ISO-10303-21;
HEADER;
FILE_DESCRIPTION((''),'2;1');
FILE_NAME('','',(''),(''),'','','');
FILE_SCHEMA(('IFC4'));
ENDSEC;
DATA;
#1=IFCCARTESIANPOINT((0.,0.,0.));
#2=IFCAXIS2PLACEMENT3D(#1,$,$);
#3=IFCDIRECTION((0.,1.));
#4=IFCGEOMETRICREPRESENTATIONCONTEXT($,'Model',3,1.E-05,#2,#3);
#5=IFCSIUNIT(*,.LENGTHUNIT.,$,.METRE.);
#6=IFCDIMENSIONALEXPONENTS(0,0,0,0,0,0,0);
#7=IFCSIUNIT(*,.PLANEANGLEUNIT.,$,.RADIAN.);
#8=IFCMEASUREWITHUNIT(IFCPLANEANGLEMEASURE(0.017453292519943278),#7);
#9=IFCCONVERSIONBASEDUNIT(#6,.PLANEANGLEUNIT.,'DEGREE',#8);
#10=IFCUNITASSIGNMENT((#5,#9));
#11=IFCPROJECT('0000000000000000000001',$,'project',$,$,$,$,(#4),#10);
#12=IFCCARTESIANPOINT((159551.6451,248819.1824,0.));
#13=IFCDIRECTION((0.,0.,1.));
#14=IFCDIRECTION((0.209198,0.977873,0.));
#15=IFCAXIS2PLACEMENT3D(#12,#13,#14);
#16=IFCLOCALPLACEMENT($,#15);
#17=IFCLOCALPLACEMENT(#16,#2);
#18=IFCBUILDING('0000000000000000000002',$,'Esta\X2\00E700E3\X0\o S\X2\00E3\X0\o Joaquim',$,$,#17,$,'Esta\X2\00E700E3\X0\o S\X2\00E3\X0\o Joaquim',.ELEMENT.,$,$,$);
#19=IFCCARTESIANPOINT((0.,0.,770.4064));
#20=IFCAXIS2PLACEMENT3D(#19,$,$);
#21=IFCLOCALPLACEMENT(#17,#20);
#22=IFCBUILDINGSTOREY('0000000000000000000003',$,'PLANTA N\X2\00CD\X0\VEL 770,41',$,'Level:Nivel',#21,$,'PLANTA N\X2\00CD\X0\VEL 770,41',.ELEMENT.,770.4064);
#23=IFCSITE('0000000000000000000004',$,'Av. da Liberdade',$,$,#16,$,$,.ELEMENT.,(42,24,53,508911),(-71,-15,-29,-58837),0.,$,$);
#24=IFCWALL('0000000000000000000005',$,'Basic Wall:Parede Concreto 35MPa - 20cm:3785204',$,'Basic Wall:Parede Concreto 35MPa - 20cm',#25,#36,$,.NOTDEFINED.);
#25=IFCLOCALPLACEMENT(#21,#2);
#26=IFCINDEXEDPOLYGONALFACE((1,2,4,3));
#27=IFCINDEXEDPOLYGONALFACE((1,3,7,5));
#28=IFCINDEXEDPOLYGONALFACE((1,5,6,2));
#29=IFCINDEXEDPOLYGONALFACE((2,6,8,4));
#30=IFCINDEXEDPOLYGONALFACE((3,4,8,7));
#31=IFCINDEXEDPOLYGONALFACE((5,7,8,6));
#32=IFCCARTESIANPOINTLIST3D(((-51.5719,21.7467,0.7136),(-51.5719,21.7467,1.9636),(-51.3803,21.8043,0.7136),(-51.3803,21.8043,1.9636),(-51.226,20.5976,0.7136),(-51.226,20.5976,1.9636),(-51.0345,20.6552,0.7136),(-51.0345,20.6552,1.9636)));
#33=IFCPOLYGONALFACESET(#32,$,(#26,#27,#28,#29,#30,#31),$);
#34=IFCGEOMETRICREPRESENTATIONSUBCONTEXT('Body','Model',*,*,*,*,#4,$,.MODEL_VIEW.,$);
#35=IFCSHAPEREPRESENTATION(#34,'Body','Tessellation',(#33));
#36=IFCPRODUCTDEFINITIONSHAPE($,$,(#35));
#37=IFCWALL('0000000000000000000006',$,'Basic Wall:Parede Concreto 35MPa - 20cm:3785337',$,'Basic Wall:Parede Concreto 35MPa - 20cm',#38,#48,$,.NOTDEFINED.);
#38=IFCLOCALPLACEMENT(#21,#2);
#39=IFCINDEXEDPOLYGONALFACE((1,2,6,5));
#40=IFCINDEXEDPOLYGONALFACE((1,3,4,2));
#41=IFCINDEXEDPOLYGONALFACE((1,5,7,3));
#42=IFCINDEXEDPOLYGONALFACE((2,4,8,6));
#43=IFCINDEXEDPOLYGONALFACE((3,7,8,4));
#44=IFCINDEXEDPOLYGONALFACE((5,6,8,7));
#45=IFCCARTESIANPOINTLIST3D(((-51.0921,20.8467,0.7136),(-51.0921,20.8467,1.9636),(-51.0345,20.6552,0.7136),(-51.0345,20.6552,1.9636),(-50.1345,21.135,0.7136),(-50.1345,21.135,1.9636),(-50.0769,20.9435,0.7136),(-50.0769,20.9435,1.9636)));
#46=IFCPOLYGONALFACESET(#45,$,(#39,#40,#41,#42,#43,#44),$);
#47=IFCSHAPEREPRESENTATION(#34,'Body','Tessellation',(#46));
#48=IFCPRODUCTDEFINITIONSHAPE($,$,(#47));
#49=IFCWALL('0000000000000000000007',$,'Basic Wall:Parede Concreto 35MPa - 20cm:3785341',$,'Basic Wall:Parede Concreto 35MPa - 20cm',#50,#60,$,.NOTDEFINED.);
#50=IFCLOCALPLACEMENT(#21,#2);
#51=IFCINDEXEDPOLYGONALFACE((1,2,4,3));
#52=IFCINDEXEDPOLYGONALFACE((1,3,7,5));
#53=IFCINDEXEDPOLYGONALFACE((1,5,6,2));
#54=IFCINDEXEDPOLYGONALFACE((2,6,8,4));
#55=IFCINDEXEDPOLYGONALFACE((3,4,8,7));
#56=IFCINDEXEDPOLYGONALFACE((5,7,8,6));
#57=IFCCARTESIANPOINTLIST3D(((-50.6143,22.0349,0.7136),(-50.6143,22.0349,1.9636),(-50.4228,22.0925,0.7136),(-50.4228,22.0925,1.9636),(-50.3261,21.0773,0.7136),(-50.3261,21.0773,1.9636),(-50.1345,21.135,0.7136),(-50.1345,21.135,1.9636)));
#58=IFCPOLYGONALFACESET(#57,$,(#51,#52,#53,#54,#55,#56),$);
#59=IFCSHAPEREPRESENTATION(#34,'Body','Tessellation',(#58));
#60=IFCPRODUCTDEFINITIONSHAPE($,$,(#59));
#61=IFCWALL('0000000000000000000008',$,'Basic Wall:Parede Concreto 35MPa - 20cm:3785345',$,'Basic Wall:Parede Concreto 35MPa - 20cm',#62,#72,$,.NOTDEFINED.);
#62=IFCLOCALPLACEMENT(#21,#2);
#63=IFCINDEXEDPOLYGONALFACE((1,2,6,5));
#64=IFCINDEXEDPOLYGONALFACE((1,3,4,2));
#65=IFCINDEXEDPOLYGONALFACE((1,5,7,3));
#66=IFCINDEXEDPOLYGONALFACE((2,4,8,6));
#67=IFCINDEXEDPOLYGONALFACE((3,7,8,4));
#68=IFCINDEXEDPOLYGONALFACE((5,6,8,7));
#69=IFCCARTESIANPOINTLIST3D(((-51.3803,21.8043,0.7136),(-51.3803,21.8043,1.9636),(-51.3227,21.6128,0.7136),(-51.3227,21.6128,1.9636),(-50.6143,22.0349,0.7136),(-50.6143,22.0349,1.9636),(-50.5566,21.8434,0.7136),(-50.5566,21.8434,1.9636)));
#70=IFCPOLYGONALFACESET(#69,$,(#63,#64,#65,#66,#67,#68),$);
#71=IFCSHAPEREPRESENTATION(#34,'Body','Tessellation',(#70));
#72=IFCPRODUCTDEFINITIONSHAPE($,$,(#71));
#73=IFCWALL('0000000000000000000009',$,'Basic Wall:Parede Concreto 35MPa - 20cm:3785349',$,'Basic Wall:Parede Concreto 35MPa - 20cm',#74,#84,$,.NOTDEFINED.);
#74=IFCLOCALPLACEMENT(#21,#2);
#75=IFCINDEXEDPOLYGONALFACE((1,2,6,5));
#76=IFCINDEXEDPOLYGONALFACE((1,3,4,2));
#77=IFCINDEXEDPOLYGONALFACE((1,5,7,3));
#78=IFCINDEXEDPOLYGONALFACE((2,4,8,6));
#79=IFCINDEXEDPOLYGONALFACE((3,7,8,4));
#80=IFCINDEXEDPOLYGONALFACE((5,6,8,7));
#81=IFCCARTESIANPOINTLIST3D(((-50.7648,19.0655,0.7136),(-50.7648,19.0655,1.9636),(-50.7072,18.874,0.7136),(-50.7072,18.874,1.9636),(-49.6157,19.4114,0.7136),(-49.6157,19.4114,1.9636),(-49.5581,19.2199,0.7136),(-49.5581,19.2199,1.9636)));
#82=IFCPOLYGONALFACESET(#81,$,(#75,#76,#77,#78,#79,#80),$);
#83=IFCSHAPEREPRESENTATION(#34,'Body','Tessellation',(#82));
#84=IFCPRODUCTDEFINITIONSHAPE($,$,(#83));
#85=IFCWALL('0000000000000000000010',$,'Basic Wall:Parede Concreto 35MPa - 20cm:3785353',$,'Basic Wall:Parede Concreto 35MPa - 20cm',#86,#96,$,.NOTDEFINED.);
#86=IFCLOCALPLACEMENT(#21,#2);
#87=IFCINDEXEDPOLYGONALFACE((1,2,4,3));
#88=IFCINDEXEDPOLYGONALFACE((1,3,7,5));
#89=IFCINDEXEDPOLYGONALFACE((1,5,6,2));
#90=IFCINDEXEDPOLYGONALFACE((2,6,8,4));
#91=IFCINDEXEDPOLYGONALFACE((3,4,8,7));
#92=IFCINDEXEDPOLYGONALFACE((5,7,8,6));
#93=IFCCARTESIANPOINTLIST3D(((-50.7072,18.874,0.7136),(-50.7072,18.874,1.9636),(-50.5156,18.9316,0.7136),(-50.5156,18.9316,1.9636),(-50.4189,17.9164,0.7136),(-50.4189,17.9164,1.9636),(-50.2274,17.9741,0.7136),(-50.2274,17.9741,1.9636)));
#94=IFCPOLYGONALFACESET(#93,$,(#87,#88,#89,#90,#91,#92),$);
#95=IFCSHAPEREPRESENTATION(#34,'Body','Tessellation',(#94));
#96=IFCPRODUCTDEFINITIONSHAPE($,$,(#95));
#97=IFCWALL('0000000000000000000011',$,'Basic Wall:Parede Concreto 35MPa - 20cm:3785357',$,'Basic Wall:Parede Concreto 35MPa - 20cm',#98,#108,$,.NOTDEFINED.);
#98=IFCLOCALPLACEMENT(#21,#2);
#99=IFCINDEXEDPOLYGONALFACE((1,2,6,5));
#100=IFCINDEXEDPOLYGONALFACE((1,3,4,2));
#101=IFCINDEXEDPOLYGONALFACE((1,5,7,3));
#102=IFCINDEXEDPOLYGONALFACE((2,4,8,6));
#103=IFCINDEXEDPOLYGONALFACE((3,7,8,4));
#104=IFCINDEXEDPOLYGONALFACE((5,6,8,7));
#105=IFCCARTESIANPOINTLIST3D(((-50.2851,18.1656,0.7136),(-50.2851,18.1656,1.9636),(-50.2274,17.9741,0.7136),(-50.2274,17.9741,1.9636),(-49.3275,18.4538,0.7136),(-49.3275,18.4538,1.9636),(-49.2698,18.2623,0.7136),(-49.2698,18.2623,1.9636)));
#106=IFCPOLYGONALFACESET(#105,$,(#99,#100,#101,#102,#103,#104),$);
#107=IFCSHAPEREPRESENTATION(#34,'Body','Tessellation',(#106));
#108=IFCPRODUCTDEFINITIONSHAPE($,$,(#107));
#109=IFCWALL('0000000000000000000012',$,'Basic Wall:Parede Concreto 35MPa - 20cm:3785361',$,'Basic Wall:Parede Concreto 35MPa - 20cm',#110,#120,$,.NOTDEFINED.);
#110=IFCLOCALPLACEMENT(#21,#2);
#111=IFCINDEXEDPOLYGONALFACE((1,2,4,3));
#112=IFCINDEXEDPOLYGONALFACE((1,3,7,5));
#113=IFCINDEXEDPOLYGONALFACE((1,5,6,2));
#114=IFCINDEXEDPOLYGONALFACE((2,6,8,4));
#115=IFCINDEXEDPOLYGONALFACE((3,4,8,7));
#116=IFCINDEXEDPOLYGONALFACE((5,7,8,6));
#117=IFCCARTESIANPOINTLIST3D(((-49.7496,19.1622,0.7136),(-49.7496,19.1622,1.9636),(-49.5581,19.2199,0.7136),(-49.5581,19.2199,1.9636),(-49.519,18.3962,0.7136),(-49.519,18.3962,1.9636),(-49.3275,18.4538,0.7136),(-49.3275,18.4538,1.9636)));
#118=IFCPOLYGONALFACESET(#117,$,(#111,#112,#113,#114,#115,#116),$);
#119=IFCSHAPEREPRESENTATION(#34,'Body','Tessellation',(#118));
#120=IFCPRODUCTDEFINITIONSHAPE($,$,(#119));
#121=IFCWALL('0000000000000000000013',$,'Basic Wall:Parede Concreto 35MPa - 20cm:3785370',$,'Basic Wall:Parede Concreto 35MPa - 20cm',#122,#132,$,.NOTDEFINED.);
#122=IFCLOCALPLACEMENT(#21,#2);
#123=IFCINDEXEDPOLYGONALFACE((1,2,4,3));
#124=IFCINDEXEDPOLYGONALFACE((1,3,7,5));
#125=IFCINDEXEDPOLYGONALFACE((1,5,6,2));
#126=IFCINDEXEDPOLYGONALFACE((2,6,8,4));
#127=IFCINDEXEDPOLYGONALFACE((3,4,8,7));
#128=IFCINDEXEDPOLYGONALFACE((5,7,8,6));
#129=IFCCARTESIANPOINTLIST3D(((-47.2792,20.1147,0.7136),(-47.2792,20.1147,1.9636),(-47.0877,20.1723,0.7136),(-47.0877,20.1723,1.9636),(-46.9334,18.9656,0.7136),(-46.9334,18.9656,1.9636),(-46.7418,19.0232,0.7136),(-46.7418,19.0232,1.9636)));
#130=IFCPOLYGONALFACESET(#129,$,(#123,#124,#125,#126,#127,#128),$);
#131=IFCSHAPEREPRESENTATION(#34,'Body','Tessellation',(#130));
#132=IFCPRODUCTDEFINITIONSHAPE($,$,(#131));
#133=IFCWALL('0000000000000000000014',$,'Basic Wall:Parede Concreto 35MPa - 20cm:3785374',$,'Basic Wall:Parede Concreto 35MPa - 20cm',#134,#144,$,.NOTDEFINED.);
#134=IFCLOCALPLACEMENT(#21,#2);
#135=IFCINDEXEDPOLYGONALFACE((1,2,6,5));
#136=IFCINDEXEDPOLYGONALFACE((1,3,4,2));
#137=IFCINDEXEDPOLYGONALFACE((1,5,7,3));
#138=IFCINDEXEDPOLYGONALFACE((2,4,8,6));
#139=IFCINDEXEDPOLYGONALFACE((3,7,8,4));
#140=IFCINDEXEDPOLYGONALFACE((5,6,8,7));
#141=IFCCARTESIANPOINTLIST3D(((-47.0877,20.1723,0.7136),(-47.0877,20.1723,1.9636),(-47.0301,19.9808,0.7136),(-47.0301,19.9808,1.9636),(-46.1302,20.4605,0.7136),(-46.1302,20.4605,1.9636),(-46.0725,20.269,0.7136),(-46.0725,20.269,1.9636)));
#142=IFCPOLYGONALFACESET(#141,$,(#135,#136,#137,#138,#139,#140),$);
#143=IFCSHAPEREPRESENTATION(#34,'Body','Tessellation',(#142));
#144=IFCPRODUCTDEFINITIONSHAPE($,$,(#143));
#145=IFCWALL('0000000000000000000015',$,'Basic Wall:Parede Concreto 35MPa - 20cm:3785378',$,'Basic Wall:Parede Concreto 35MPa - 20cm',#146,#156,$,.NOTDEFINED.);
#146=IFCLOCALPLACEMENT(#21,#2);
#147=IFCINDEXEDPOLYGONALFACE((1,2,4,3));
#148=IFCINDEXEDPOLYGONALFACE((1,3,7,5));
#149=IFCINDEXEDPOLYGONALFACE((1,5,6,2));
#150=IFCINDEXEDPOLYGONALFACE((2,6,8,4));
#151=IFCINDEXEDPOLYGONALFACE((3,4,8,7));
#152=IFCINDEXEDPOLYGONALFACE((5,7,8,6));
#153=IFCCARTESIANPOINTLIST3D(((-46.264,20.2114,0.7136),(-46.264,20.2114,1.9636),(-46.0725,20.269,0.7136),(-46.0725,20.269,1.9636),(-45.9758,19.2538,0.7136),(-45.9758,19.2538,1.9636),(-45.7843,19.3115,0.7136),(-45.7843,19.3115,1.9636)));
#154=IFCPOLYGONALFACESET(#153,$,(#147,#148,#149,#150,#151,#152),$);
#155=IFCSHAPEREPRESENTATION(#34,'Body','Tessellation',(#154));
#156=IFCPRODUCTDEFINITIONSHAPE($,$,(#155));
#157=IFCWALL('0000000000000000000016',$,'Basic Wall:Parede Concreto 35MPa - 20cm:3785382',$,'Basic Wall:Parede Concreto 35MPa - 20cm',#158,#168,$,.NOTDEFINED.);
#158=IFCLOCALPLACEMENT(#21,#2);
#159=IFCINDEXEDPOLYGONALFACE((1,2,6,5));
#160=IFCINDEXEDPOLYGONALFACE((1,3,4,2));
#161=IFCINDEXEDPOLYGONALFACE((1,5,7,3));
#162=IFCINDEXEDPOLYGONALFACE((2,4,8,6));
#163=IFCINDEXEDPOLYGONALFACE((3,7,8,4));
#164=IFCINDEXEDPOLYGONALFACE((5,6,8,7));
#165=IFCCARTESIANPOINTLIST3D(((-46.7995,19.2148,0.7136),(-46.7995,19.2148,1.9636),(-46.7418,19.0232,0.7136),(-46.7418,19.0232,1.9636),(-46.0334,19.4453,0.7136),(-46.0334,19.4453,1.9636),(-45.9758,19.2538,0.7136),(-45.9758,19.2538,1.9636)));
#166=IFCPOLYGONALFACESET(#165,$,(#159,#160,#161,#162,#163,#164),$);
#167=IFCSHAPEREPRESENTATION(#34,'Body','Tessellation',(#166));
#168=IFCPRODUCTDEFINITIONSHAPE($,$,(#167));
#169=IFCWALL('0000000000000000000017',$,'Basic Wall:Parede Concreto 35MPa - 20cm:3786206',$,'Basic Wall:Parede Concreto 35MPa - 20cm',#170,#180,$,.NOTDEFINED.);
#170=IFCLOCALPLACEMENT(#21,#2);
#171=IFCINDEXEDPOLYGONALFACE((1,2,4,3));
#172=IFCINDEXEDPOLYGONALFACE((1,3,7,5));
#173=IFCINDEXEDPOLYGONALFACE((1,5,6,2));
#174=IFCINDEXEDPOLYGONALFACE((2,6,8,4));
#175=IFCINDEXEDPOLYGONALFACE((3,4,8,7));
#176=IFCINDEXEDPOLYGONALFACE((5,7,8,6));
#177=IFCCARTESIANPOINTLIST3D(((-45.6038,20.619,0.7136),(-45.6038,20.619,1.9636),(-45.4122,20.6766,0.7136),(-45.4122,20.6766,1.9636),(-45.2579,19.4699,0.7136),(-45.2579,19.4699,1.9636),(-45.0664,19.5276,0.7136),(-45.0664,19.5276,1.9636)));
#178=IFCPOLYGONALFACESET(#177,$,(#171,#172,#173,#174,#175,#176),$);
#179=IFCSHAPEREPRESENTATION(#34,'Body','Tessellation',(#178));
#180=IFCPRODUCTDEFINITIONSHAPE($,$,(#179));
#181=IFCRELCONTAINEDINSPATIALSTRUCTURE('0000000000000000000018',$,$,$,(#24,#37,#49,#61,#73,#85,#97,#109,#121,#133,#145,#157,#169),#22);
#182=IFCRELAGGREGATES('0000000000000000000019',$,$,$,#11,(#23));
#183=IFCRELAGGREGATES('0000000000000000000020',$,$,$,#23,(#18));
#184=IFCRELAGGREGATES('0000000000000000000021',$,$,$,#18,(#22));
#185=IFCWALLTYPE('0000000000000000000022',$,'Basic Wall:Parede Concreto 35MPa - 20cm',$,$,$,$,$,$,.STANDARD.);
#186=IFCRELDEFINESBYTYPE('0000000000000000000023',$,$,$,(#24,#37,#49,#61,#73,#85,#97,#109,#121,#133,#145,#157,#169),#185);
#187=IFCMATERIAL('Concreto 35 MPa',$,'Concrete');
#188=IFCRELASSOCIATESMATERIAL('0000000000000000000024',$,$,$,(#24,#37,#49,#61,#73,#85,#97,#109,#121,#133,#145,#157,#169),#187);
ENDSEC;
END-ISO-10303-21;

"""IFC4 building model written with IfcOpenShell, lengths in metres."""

from ifc_helpers import new_model, entity, si_unit, converted_unit, direction, frame, origin, place, context, subcontext, project, spatial, indexed_curve, outline, extrude, material, type_object, element, save


model = new_model("IFC4")

# Units and contexts
model_context = context("Model", 3, precision=1e-05, world=origin(), true_north=direction((0.0, 1.0)))
body_context = subcontext(model_context, "Body", "Model", "MODEL_VIEW")
ifc_project = project(units=[si_unit("LENGTHUNIT", "METRE"), converted_unit("PLANEANGLEUNIT", "DEGREE", entity("IfcPlaneAngleMeasure", 0.017453292519943278), si_unit("PLANEANGLEUNIT", "RADIAN"), dimensions=[0, 0, 0, 0, 0, 0, 0])], contexts=[model_context])

# Site, building, storey
site_placement = place(None, frame((159551.6451, 248819.1824, 0.0), z_axis=(0.0, 0.0, 1.0), x_axis=(0.209198, 0.977873, 0.0)))
site = spatial("IfcSite", under=ifc_project, at=site_placement, Name="Av. da Liberdade", CompositionType="ELEMENT", RefLatitude=(42, 24, 53, 508911), RefLongitude=(-71, -15, -29, -58837), RefElevation=0.0)
building_placement = place(site_placement, origin())
building = spatial("IfcBuilding", under=site, at=building_placement, Name="Estação São Joaquim", LongName="Estação São Joaquim", CompositionType="ELEMENT")
storey_placement = place(building_placement, frame((0.0, 0.0, 770.4064)))
storey = spatial("IfcBuildingStorey", under=building, at=storey_placement, Name="PLANTA NÍVEL 770,41", ObjectType="Level:Nivel", LongName="PLANTA NÍVEL 770,41", CompositionType="ELEMENT", Elevation=770.4064)

# Walls
ifc_material = material(Name="Concreto 35 MPa", Category="Concrete")
wall_type = type_object("IfcWallType", Name="Basic Wall:Parede Concreto 35MPa - 20cm", PredefinedType="STANDARD")
wall_1_placement = place(storey_placement, frame((-51.1302, 20.6264, 0.7136), z_axis=(0.0, 0.0, 1.0), x_axis=(-0.288234, 0.95756, 0.0)))
element("IfcWall", 1, at=wall_1_placement, inside=storey, type_object=wall_type, material=ifc_material, Name="Basic Wall:Parede Concreto 35MPa - 20cm:3785204", ObjectType="Basic Wall:Parede Concreto 35MPa - 20cm", PredefinedType="NOTDEFINED", context=body_context, shape_type="SweptSolid", body=[
    extrude(outline(indexed_curve([(1.2, 0.1), (0.0, 0.1), (0.0, -0.1), (1.2, -0.1), (1.2, 0.1)], self_intersect=False)), origin(), (0.0, 0.0, 1.0), 1.25),
])
wall_2_placement = place(storey_placement, frame((-50.1057, 21.0392, 0.7136), z_axis=(0.0, 0.0, 1.0), x_axis=(-0.95756, -0.288234, 0.0)))
element("IfcWall", 2, at=wall_2_placement, inside=storey, type_object=wall_type, material=ifc_material, Name="Basic Wall:Parede Concreto 35MPa - 20cm:3785337", ObjectType="Basic Wall:Parede Concreto 35MPa - 20cm", PredefinedType="NOTDEFINED", context=body_context, shape_type="SweptSolid", body=[
    extrude(outline(indexed_curve([(1.0, 0.1), (0.0, 0.1), (0.0, -0.1), (1.0, -0.1), (1.0, 0.1)], self_intersect=False)), origin(), (0.0, 0.0, 1.0), 1.25),
])
wall_3_placement = place(storey_placement, frame((-50.5185, 22.0637, 0.7136), z_axis=(0.0, 0.0, 1.0), x_axis=(0.288234, -0.95756, 0.0)))
element("IfcWall", 3, at=wall_3_placement, inside=storey, type_object=wall_type, material=ifc_material, Name="Basic Wall:Parede Concreto 35MPa - 20cm:3785341", ObjectType="Basic Wall:Parede Concreto 35MPa - 20cm", PredefinedType="NOTDEFINED", context=body_context, shape_type="SweptSolid", body=[
    extrude(outline(indexed_curve([(1.0, 0.1), (0.0, 0.1), (0.0, -0.1), (1.0, -0.1), (1.0, 0.1)], self_intersect=False)), origin(), (0.0, 0.0, 1.0), 1.25),
])
wall_4_placement = place(storey_placement, frame((-51.3515, 21.7085, 0.7136), z_axis=(0.0, 0.0, 1.0), x_axis=(0.95756, 0.288234, 0.0)))
element("IfcWall", 4, at=wall_4_placement, inside=storey, type_object=wall_type, material=ifc_material, Name="Basic Wall:Parede Concreto 35MPa - 20cm:3785345", ObjectType="Basic Wall:Parede Concreto 35MPa - 20cm", PredefinedType="NOTDEFINED", context=body_context, shape_type="SweptSolid", body=[
    extrude(outline(indexed_curve([(0.8, 0.1), (0.0, 0.1), (0.0, -0.1), (0.8, -0.1), (0.8, 0.1)], self_intersect=False)), origin(), (0.0, 0.0, 1.0), 1.25),
])
wall_5_placement = place(storey_placement, frame((-50.736, 18.9697, 0.7136), z_axis=(0.0, 0.0, 1.0), x_axis=(0.95756, 0.288234, 0.0)))
element("IfcWall", 5, at=wall_5_placement, inside=storey, type_object=wall_type, material=ifc_material, Name="Basic Wall:Parede Concreto 35MPa - 20cm:3785349", ObjectType="Basic Wall:Parede Concreto 35MPa - 20cm", PredefinedType="NOTDEFINED", context=body_context, shape_type="SweptSolid", body=[
    extrude(outline(indexed_curve([(1.2, 0.1), (0.0, 0.1), (0.0, -0.1), (1.2, -0.1), (1.2, 0.1)], self_intersect=False)), origin(), (0.0, 0.0, 1.0), 1.25),
])
wall_6_placement = place(storey_placement, frame((-50.3232, 17.9452, 0.7136), z_axis=(0.0, 0.0, 1.0), x_axis=(-0.288234, 0.95756, 0.0)))
element("IfcWall", 6, at=wall_6_placement, inside=storey, type_object=wall_type, material=ifc_material, Name="Basic Wall:Parede Concreto 35MPa - 20cm:3785353", ObjectType="Basic Wall:Parede Concreto 35MPa - 20cm", PredefinedType="NOTDEFINED", context=body_context, shape_type="SweptSolid", body=[
    extrude(outline(indexed_curve([(1.0, 0.1), (0.0, 0.1), (0.0, -0.1), (1.0, -0.1), (1.0, 0.1)], self_intersect=False)), origin(), (0.0, 0.0, 1.0), 1.25),
])
wall_7_placement = place(storey_placement, frame((-49.2987, 18.358, 0.7136), z_axis=(0.0, 0.0, 1.0), x_axis=(-0.95756, -0.288234, 0.0)))
element("IfcWall", 7, at=wall_7_placement, inside=storey, type_object=wall_type, material=ifc_material, Name="Basic Wall:Parede Concreto 35MPa - 20cm:3785357", ObjectType="Basic Wall:Parede Concreto 35MPa - 20cm", PredefinedType="NOTDEFINED", context=body_context, shape_type="SweptSolid", body=[
    extrude(outline(indexed_curve([(1.0, 0.1), (0.0, 0.1), (0.0, -0.1), (1.0, -0.1), (1.0, 0.1)], self_intersect=False)), origin(), (0.0, 0.0, 1.0), 1.25),
])
wall_8_placement = place(storey_placement, frame((-49.6538, 19.191, 0.7136), z_axis=(0.0, 0.0, 1.0), x_axis=(0.288234, -0.95756, 0.0)))
element("IfcWall", 8, at=wall_8_placement, inside=storey, type_object=wall_type, material=ifc_material, Name="Basic Wall:Parede Concreto 35MPa - 20cm:3785361", ObjectType="Basic Wall:Parede Concreto 35MPa - 20cm", PredefinedType="NOTDEFINED", context=body_context, shape_type="SweptSolid", body=[
    extrude(outline(indexed_curve([(0.8, 0.1), (0.0, 0.1), (0.0, -0.1), (0.8, -0.1), (0.8, 0.1)], self_intersect=False)), origin(), (0.0, 0.0, 1.0), 1.25),
])
wall_9_placement = place(storey_placement, frame((-46.8376, 18.9944, 0.7136), z_axis=(0.0, 0.0, 1.0), x_axis=(-0.288234, 0.95756, 0.0)))
element("IfcWall", 9, at=wall_9_placement, inside=storey, type_object=wall_type, material=ifc_material, Name="Basic Wall:Parede Concreto 35MPa - 20cm:3785370", ObjectType="Basic Wall:Parede Concreto 35MPa - 20cm", PredefinedType="NOTDEFINED", context=body_context, shape_type="SweptSolid", body=[
    extrude(outline(indexed_curve([(1.2, 0.1), (0.0, 0.1), (0.0, -0.1), (1.2, -0.1), (1.2, 0.1)], self_intersect=False)), origin(), (0.0, 0.0, 1.0), 1.25),
])
wall_10_placement = place(storey_placement, frame((-47.0589, 20.0766, 0.7136), z_axis=(0.0, 0.0, 1.0), x_axis=(0.95756, 0.288234, 0.0)))
element("IfcWall", 10, at=wall_10_placement, inside=storey, type_object=wall_type, material=ifc_material, Name="Basic Wall:Parede Concreto 35MPa - 20cm:3785374", ObjectType="Basic Wall:Parede Concreto 35MPa - 20cm", PredefinedType="NOTDEFINED", context=body_context, shape_type="SweptSolid", body=[
    extrude(outline(indexed_curve([(1.0, 0.1), (0.0, 0.1), (0.0, -0.1), (1.0, -0.1), (1.0, 0.1)], self_intersect=False)), origin(), (0.0, 0.0, 1.0), 1.25),
])
wall_11_placement = place(storey_placement, frame((-46.1683, 20.2402, 0.7136), z_axis=(0.0, 0.0, 1.0), x_axis=(0.288234, -0.95756, 0.0)))
element("IfcWall", 11, at=wall_11_placement, inside=storey, type_object=wall_type, material=ifc_material, Name="Basic Wall:Parede Concreto 35MPa - 20cm:3785378", ObjectType="Basic Wall:Parede Concreto 35MPa - 20cm", PredefinedType="NOTDEFINED", context=body_context, shape_type="SweptSolid", body=[
    extrude(outline(indexed_curve([(1.0, 0.1), (0.0, 0.1), (0.0, -0.1), (1.0, -0.1), (1.0, 0.1)], self_intersect=False)), origin(), (0.0, 0.0, 1.0), 1.25),
])
wall_12_placement = place(storey_placement, frame((-46.0046, 19.3496, 0.7136), z_axis=(0.0, 0.0, 1.0), x_axis=(-0.95756, -0.288234, 0.0)))
element("IfcWall", 12, at=wall_12_placement, inside=storey, type_object=wall_type, material=ifc_material, Name="Basic Wall:Parede Concreto 35MPa - 20cm:3785382", ObjectType="Basic Wall:Parede Concreto 35MPa - 20cm", PredefinedType="NOTDEFINED", context=body_context, shape_type="SweptSolid", body=[
    extrude(outline(indexed_curve([(0.8, 0.1), (0.0, 0.1), (0.0, -0.1), (0.8, -0.1), (0.8, 0.1)], self_intersect=False)), origin(), (0.0, 0.0, 1.0), 1.25),
])
wall_13_placement = place(storey_placement, frame((-45.1621, 19.4988, 0.7136), z_axis=(0.0, 0.0, 1.0), x_axis=(-0.288234, 0.95756, 0.0)))
element("IfcWall", 13, at=wall_13_placement, inside=storey, type_object=wall_type, material=ifc_material, Name="Basic Wall:Parede Concreto 35MPa - 20cm:3786206", ObjectType="Basic Wall:Parede Concreto 35MPa - 20cm", PredefinedType="NOTDEFINED", context=body_context, shape_type="SweptSolid", body=[
    extrude(outline(indexed_curve([(1.2, 0.1), (0.0, 0.1), (0.0, -0.1), (1.2, -0.1), (1.2, 0.1)], self_intersect=False)), origin(), (0.0, 0.0, 1.0), 1.25),
])

save(model, "model.ifc")
